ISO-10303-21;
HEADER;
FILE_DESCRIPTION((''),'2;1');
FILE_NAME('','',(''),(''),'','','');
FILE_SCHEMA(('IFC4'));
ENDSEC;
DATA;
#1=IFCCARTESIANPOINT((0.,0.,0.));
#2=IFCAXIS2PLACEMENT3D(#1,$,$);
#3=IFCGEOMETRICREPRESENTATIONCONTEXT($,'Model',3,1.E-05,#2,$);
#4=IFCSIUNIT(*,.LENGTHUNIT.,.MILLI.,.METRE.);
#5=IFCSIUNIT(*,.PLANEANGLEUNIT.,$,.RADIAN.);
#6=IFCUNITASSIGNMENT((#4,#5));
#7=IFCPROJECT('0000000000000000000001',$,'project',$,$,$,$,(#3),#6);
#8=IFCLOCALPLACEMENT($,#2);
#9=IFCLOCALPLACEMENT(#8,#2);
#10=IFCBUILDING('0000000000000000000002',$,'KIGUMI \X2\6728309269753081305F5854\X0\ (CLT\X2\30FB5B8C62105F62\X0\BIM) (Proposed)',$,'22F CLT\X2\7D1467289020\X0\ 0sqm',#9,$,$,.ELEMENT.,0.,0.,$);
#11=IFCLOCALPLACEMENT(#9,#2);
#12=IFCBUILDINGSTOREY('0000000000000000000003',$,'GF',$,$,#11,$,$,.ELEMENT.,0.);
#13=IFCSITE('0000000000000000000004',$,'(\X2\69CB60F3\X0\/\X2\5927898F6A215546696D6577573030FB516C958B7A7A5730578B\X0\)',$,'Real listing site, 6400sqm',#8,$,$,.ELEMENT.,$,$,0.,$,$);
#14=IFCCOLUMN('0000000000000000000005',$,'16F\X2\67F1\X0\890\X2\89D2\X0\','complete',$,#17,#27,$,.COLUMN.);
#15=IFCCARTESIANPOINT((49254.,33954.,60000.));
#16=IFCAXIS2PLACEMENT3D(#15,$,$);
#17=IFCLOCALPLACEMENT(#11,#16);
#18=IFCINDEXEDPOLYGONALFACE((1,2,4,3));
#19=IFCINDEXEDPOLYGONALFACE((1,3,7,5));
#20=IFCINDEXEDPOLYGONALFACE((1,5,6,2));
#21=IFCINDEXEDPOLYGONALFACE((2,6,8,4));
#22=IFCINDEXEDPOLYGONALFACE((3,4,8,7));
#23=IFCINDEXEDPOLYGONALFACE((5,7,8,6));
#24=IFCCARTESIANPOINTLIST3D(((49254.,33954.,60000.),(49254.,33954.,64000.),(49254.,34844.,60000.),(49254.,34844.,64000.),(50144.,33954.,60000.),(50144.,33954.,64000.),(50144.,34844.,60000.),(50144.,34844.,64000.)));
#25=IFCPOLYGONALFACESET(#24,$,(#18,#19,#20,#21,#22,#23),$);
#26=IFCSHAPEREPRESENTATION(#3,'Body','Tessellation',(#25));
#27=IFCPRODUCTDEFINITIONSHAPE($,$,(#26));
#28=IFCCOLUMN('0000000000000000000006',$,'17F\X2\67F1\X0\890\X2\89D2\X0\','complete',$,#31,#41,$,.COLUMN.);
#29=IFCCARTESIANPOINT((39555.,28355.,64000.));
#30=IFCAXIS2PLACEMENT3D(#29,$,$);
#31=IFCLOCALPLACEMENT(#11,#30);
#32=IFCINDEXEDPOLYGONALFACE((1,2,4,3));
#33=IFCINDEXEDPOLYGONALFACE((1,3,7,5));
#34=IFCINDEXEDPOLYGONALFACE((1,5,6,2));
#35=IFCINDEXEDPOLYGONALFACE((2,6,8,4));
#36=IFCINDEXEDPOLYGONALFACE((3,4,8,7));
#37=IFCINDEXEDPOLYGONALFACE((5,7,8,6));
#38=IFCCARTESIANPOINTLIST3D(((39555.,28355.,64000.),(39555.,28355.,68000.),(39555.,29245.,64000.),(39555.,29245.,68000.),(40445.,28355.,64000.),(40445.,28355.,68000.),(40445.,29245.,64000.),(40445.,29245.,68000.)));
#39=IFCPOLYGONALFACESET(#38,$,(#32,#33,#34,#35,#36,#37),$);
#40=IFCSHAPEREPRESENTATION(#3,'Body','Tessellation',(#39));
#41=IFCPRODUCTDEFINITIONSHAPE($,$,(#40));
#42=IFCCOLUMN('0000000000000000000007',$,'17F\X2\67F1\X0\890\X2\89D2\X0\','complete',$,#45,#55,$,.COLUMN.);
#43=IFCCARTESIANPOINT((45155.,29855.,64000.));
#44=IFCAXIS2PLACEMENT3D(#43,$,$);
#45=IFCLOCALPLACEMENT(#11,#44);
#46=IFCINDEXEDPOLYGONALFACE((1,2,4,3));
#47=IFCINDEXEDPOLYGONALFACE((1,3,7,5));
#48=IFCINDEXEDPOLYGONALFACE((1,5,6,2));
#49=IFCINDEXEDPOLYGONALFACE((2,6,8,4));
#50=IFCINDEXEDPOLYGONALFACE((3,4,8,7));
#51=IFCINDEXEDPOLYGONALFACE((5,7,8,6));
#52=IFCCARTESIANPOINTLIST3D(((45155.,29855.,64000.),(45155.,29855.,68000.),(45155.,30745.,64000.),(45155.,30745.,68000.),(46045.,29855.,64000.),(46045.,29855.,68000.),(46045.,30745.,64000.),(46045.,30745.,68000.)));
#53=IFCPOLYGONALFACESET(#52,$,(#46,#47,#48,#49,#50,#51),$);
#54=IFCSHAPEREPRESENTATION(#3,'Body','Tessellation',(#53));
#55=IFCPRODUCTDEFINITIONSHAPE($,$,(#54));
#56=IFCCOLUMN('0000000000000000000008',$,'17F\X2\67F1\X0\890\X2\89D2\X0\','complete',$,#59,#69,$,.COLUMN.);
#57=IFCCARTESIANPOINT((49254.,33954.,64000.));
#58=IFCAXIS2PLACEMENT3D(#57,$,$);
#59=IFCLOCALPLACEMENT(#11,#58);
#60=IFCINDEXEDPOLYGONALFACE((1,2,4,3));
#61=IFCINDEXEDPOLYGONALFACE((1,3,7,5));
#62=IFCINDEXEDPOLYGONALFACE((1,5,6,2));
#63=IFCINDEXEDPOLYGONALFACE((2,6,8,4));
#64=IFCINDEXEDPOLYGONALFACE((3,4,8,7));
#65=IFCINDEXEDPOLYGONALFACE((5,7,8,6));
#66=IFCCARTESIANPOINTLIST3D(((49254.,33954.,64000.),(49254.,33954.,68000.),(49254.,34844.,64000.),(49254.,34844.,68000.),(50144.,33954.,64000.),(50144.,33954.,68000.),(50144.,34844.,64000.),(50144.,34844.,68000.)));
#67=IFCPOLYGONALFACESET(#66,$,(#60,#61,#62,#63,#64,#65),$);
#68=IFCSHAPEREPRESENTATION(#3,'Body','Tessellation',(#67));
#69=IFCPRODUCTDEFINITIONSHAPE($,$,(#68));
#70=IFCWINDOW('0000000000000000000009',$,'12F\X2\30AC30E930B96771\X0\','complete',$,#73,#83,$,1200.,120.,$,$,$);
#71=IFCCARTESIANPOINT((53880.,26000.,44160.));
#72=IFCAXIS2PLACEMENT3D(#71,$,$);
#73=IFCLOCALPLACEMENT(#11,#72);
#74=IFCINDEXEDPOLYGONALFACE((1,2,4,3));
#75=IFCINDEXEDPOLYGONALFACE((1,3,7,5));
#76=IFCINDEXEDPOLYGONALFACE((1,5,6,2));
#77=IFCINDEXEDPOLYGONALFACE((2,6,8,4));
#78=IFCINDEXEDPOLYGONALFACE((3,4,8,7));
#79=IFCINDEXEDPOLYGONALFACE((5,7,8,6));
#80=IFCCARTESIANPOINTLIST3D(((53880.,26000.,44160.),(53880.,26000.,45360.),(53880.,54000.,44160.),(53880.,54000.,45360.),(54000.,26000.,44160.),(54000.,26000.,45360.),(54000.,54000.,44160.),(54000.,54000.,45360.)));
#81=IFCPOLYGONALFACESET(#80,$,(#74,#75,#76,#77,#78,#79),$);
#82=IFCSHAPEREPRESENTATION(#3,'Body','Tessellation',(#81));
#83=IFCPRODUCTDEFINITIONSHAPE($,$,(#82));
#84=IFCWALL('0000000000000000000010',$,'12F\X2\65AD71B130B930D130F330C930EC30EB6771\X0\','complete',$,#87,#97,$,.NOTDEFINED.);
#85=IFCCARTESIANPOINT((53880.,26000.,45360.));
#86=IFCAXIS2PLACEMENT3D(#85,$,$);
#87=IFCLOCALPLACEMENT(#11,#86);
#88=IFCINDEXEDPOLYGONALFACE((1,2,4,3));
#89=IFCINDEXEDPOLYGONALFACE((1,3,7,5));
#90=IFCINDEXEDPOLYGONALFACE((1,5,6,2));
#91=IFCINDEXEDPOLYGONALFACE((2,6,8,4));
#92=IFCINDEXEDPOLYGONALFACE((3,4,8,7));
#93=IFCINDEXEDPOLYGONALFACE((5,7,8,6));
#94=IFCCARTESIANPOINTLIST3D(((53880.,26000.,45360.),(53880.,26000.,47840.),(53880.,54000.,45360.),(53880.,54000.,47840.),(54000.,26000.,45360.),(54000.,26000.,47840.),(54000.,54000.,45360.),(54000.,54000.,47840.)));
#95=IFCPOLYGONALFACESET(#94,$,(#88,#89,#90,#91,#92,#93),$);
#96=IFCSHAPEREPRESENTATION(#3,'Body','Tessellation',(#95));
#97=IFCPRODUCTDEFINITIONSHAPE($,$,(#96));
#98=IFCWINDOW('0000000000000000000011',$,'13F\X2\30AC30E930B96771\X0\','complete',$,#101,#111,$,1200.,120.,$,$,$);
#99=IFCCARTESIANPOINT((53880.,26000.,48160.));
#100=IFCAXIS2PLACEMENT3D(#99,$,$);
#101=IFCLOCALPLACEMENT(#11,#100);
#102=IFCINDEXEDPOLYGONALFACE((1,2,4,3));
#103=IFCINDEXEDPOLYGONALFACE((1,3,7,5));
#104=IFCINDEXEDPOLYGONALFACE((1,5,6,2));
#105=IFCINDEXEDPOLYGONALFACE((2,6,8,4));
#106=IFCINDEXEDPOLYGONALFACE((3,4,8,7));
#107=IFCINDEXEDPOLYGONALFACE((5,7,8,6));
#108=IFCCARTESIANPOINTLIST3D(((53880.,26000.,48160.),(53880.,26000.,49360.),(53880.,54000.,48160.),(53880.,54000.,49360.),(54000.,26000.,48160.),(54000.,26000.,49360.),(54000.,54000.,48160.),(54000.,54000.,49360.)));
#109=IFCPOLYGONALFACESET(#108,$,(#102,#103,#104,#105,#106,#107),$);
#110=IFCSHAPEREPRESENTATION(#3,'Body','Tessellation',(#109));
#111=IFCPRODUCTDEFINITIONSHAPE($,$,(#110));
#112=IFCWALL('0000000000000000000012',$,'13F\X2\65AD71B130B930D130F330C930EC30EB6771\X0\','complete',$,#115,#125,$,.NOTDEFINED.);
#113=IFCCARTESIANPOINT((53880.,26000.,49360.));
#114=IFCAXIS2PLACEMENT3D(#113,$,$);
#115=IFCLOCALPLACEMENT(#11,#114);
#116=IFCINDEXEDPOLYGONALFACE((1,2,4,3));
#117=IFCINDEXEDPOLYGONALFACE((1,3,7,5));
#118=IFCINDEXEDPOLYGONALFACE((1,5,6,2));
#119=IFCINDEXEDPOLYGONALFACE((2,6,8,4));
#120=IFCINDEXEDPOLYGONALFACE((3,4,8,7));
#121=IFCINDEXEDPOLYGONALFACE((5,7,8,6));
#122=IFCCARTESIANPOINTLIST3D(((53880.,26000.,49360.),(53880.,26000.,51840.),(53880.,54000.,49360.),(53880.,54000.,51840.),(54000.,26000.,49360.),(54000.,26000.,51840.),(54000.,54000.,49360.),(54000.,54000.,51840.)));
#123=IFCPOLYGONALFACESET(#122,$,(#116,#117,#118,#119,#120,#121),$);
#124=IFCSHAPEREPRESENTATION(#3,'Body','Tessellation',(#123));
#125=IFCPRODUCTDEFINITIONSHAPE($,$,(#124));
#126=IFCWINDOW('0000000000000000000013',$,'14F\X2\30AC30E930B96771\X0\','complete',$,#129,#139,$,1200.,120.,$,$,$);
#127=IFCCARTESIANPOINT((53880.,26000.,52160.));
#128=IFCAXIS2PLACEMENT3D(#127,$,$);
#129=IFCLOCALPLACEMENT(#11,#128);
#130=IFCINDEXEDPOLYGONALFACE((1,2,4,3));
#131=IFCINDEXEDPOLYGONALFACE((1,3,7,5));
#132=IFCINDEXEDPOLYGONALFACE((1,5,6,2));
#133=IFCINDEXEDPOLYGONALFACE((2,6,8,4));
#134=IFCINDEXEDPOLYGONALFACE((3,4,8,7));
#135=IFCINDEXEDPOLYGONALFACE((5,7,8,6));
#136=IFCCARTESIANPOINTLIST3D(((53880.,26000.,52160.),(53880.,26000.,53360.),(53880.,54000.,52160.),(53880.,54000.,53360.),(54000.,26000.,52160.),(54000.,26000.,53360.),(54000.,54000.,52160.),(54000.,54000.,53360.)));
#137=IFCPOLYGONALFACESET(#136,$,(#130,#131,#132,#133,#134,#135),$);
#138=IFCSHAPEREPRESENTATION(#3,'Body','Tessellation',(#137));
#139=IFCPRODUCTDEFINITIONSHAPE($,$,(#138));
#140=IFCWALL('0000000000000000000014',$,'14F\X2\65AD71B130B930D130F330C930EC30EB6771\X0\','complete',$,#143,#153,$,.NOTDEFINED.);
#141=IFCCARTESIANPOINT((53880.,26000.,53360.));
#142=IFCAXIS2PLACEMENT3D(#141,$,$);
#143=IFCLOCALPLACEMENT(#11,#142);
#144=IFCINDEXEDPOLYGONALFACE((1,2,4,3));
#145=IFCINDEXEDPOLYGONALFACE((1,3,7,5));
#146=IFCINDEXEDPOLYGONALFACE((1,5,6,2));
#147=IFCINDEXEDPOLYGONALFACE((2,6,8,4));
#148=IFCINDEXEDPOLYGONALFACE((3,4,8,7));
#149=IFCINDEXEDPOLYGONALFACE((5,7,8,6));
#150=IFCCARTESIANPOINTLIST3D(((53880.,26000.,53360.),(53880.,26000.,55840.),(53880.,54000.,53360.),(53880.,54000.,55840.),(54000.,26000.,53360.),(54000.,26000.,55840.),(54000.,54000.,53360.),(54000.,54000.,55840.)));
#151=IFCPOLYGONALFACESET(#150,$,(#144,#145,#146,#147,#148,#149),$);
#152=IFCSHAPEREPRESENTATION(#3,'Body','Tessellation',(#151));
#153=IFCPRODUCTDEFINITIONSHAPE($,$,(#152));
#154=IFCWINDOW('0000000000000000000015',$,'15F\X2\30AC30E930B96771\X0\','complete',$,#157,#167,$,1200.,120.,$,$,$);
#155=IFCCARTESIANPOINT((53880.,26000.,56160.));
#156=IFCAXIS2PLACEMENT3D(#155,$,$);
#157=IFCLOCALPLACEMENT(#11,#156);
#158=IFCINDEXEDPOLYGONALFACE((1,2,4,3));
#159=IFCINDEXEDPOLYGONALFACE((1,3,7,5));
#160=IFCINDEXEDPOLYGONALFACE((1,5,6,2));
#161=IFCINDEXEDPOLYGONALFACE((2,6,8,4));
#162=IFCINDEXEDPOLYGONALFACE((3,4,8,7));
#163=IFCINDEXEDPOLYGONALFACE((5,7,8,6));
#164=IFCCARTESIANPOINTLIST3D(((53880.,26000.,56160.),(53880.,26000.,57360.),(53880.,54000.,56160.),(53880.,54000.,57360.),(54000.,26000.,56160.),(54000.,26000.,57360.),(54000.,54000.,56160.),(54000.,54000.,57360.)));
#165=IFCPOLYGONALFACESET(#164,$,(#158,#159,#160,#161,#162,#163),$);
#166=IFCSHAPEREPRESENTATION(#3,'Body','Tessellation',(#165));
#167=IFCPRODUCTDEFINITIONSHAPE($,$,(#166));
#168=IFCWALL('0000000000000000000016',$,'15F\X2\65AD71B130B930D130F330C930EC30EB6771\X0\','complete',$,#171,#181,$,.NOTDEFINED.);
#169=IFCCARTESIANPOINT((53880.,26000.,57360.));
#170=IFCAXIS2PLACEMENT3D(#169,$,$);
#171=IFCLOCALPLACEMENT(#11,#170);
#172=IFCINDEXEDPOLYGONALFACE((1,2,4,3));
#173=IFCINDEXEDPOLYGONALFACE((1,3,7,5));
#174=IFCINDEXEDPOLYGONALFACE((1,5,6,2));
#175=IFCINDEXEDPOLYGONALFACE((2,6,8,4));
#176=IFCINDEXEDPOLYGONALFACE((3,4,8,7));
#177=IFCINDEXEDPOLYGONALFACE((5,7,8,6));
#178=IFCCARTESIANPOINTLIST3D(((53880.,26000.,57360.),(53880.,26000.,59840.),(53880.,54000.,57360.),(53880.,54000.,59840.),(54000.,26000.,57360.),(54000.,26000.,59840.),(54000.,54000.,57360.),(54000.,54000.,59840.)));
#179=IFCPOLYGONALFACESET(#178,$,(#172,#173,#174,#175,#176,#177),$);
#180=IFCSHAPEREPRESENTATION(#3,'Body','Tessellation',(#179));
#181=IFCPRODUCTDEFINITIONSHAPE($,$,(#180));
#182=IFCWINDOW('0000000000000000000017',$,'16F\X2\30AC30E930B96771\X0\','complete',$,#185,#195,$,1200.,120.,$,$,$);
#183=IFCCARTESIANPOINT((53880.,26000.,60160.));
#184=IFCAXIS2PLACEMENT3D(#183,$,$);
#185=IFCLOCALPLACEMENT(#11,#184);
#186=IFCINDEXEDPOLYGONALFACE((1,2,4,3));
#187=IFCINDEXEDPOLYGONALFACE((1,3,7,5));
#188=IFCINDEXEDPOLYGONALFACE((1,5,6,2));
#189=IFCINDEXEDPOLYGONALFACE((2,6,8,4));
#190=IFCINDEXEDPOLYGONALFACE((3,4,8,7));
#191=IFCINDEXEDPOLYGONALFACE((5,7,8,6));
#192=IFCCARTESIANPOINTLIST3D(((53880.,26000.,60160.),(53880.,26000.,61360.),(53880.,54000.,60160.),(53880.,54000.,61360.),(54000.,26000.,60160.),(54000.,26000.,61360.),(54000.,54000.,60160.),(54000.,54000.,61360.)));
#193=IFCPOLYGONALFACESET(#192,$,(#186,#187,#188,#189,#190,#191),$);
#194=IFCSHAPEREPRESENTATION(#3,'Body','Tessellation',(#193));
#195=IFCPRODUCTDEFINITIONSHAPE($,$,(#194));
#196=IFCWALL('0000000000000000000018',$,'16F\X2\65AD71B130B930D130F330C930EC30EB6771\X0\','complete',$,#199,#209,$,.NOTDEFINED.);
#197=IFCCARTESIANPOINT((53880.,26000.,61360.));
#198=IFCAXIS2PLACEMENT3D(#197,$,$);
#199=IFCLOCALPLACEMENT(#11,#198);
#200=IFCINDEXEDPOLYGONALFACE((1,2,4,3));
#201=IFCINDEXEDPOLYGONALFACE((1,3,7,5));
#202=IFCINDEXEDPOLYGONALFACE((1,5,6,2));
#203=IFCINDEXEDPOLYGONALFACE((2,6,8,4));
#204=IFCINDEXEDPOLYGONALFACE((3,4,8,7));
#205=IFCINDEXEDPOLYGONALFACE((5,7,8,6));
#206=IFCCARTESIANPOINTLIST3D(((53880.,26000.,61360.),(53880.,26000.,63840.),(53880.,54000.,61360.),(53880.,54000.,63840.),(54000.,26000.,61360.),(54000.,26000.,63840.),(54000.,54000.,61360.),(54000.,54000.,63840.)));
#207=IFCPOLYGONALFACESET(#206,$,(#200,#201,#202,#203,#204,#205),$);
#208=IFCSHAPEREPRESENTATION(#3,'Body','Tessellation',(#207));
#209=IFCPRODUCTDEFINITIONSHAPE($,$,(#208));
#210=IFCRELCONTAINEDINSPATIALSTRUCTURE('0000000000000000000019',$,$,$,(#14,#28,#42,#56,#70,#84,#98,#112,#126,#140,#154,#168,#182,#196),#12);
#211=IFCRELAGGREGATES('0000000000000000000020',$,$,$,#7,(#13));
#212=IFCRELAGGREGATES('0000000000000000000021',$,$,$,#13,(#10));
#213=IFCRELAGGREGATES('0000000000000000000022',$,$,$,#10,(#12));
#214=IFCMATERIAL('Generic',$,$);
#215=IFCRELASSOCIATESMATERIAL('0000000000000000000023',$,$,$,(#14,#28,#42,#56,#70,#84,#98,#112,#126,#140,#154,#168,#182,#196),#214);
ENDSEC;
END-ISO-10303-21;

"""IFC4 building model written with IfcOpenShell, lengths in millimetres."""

from ifc_helpers import new_model, si_unit, frame, frame_2d, origin, place, context, project, spatial, rectangle, extrude, material, element, save


model = new_model("IFC4")

# Units and contexts
model_context = context("Model", 3, precision=1e-05, world=origin())
ifc_project = project(units=[si_unit("LENGTHUNIT", "METRE", prefix="MILLI"), si_unit("PLANEANGLEUNIT", "RADIAN")], contexts=[model_context])

# Site, building, storey
site_placement = place(None, origin())
site = spatial("IfcSite", under=ifc_project, at=site_placement, Name="(構想/大規模商業敷地・公開空地型)", ObjectType="Real listing site, 6400sqm", CompositionType="ELEMENT", RefElevation=0.0)
building_placement = place(site_placement, origin())
building = spatial("IfcBuilding", under=site, at=building_placement, Name="KIGUMI 木を極めた塔 (CLT・完成形BIM) (Proposed)", ObjectType="22F CLT純木造 0sqm", CompositionType="ELEMENT", ElevationOfRefHeight=0.0, ElevationOfTerrain=0.0)
storey_placement = place(building_placement, origin())
storey = spatial("IfcBuildingStorey", under=building, at=storey_placement, Name="GF", CompositionType="ELEMENT", Elevation=0.0)

# Columns
ifc_material = material(Name="Generic")
column_1_placement = place(storey_placement, frame((49254.0, 33954.0, 60000.0)))
element("IfcColumn", 1, at=column_1_placement, inside=storey, material=ifc_material, Name="16F柱890角", Description="complete", PredefinedType="COLUMN", context=model_context, shape_type="SweptSolid", body=[
    extrude(rectangle(XDim=890.0, YDim=890.0, at=frame_2d((445.0, 445.0))), frame((49254.0, 33954.0, 60000.0)), (0.0, 0.0, 1.0), 4000.0),
])
column_2_placement = place(storey_placement, frame((39555.0, 28355.0, 64000.0)))
element("IfcColumn", 2, at=column_2_placement, inside=storey, material=ifc_material, Name="17F柱890角", Description="complete", PredefinedType="COLUMN", context=model_context, shape_type="SweptSolid", body=[
    extrude(rectangle(XDim=890.0, YDim=890.0, at=frame_2d((445.0, 445.0))), frame((39555.0, 28355.0, 64000.0)), (0.0, 0.0, 1.0), 4000.0),
])
column_3_placement = place(storey_placement, frame((45155.0, 29855.0, 64000.0)))
element("IfcColumn", 3, at=column_3_placement, inside=storey, material=ifc_material, Name="17F柱890角", Description="complete", PredefinedType="COLUMN", context=model_context, shape_type="SweptSolid", body=[
    extrude(rectangle(XDim=890.0, YDim=890.0, at=frame_2d((445.0, 445.0))), frame((45155.0, 29855.0, 64000.0)), (0.0, 0.0, 1.0), 4000.0),
])
column_4_placement = place(storey_placement, frame((49254.0, 33954.0, 64000.0)))
element("IfcColumn", 4, at=column_4_placement, inside=storey, material=ifc_material, Name="17F柱890角", Description="complete", PredefinedType="COLUMN", context=model_context, shape_type="SweptSolid", body=[
    extrude(rectangle(XDim=890.0, YDim=890.0, at=frame_2d((445.0, 445.0))), frame((49254.0, 33954.0, 64000.0)), (0.0, 0.0, 1.0), 4000.0),
])

# Window
window_1_placement = place(storey_placement, frame((53880.0, 26000.0, 44160.0)))
element("IfcWindow", 5, at=window_1_placement, inside=storey, material=ifc_material, Name="12Fガラス東", Description="complete", OverallHeight=1200.0, OverallWidth=120.0, context=model_context, shape_type="SweptSolid", body=[
    extrude(rectangle(XDim=120.0, YDim=28000.0, at=frame_2d((60.0, 14000.0))), frame((53880.0, 26000.0, 44160.0)), (0.0, 0.0, 1.0), 1200.0),
])

# Wall
wall_1_placement = place(storey_placement, frame((53880.0, 26000.0, 45360.0)))
element("IfcWall", 6, at=wall_1_placement, inside=storey, material=ifc_material, Name="12F断熱スパンドレル東", Description="complete", PredefinedType="NOTDEFINED", context=model_context, shape_type="SweptSolid", body=[
    extrude(rectangle(XDim=120.0, YDim=28000.0, at=frame_2d((60.0, 14000.0))), frame((53880.0, 26000.0, 45360.0)), (0.0, 0.0, 1.0), 2480.0),
])

# Window
window_2_placement = place(storey_placement, frame((53880.0, 26000.0, 48160.0)))
element("IfcWindow", 7, at=window_2_placement, inside=storey, material=ifc_material, Name="13Fガラス東", Description="complete", OverallHeight=1200.0, OverallWidth=120.0, context=model_context, shape_type="SweptSolid", body=[
    extrude(rectangle(XDim=120.0, YDim=28000.0, at=frame_2d((60.0, 14000.0))), frame((53880.0, 26000.0, 48160.0)), (0.0, 0.0, 1.0), 1200.0),
])

# Wall
wall_2_placement = place(storey_placement, frame((53880.0, 26000.0, 49360.0)))
element("IfcWall", 8, at=wall_2_placement, inside=storey, material=ifc_material, Name="13F断熱スパンドレル東", Description="complete", PredefinedType="NOTDEFINED", context=model_context, shape_type="SweptSolid", body=[
    extrude(rectangle(XDim=120.0, YDim=28000.0, at=frame_2d((60.0, 14000.0))), frame((53880.0, 26000.0, 49360.0)), (0.0, 0.0, 1.0), 2480.0),
])

# Window
window_3_placement = place(storey_placement, frame((53880.0, 26000.0, 52160.0)))
element("IfcWindow", 9, at=window_3_placement, inside=storey, material=ifc_material, Name="14Fガラス東", Description="complete", OverallHeight=1200.0, OverallWidth=120.0, context=model_context, shape_type="SweptSolid", body=[
    extrude(rectangle(XDim=120.0, YDim=28000.0, at=frame_2d((60.0, 14000.0))), frame((53880.0, 26000.0, 52160.0)), (0.0, 0.0, 1.0), 1200.0),
])

# Wall
wall_3_placement = place(storey_placement, frame((53880.0, 26000.0, 53360.0)))
element("IfcWall", 10, at=wall_3_placement, inside=storey, material=ifc_material, Name="14F断熱スパンドレル東", Description="complete", PredefinedType="NOTDEFINED", context=model_context, shape_type="SweptSolid", body=[
    extrude(rectangle(XDim=120.0, YDim=28000.0, at=frame_2d((60.0, 14000.0))), frame((53880.0, 26000.0, 53360.0)), (0.0, 0.0, 1.0), 2480.0),
])

# Window
window_4_placement = place(storey_placement, frame((53880.0, 26000.0, 56160.0)))
element("IfcWindow", 11, at=window_4_placement, inside=storey, material=ifc_material, Name="15Fガラス東", Description="complete", OverallHeight=1200.0, OverallWidth=120.0, context=model_context, shape_type="SweptSolid", body=[
    extrude(rectangle(XDim=120.0, YDim=28000.0, at=frame_2d((60.0, 14000.0))), frame((53880.0, 26000.0, 56160.0)), (0.0, 0.0, 1.0), 1200.0),
])

# Wall
wall_4_placement = place(storey_placement, frame((53880.0, 26000.0, 57360.0)))
element("IfcWall", 12, at=wall_4_placement, inside=storey, material=ifc_material, Name="15F断熱スパンドレル東", Description="complete", PredefinedType="NOTDEFINED", context=model_context, shape_type="SweptSolid", body=[
    extrude(rectangle(XDim=120.0, YDim=28000.0, at=frame_2d((60.0, 14000.0))), frame((53880.0, 26000.0, 57360.0)), (0.0, 0.0, 1.0), 2480.0),
])

# Window
window_5_placement = place(storey_placement, frame((53880.0, 26000.0, 60160.0)))
element("IfcWindow", 13, at=window_5_placement, inside=storey, material=ifc_material, Name="16Fガラス東", Description="complete", OverallHeight=1200.0, OverallWidth=120.0, context=model_context, shape_type="SweptSolid", body=[
    extrude(rectangle(XDim=120.0, YDim=28000.0, at=frame_2d((60.0, 14000.0))), frame((53880.0, 26000.0, 60160.0)), (0.0, 0.0, 1.0), 1200.0),
])

# Wall
wall_5_placement = place(storey_placement, frame((53880.0, 26000.0, 61360.0)))
element("IfcWall", 14, at=wall_5_placement, inside=storey, material=ifc_material, Name="16F断熱スパンドレル東", Description="complete", PredefinedType="NOTDEFINED", context=model_context, shape_type="SweptSolid", body=[
    extrude(rectangle(XDim=120.0, YDim=28000.0, at=frame_2d((60.0, 14000.0))), frame((53880.0, 26000.0, 61360.0)), (0.0, 0.0, 1.0), 2480.0),
])

save(model, "model.ifc")
